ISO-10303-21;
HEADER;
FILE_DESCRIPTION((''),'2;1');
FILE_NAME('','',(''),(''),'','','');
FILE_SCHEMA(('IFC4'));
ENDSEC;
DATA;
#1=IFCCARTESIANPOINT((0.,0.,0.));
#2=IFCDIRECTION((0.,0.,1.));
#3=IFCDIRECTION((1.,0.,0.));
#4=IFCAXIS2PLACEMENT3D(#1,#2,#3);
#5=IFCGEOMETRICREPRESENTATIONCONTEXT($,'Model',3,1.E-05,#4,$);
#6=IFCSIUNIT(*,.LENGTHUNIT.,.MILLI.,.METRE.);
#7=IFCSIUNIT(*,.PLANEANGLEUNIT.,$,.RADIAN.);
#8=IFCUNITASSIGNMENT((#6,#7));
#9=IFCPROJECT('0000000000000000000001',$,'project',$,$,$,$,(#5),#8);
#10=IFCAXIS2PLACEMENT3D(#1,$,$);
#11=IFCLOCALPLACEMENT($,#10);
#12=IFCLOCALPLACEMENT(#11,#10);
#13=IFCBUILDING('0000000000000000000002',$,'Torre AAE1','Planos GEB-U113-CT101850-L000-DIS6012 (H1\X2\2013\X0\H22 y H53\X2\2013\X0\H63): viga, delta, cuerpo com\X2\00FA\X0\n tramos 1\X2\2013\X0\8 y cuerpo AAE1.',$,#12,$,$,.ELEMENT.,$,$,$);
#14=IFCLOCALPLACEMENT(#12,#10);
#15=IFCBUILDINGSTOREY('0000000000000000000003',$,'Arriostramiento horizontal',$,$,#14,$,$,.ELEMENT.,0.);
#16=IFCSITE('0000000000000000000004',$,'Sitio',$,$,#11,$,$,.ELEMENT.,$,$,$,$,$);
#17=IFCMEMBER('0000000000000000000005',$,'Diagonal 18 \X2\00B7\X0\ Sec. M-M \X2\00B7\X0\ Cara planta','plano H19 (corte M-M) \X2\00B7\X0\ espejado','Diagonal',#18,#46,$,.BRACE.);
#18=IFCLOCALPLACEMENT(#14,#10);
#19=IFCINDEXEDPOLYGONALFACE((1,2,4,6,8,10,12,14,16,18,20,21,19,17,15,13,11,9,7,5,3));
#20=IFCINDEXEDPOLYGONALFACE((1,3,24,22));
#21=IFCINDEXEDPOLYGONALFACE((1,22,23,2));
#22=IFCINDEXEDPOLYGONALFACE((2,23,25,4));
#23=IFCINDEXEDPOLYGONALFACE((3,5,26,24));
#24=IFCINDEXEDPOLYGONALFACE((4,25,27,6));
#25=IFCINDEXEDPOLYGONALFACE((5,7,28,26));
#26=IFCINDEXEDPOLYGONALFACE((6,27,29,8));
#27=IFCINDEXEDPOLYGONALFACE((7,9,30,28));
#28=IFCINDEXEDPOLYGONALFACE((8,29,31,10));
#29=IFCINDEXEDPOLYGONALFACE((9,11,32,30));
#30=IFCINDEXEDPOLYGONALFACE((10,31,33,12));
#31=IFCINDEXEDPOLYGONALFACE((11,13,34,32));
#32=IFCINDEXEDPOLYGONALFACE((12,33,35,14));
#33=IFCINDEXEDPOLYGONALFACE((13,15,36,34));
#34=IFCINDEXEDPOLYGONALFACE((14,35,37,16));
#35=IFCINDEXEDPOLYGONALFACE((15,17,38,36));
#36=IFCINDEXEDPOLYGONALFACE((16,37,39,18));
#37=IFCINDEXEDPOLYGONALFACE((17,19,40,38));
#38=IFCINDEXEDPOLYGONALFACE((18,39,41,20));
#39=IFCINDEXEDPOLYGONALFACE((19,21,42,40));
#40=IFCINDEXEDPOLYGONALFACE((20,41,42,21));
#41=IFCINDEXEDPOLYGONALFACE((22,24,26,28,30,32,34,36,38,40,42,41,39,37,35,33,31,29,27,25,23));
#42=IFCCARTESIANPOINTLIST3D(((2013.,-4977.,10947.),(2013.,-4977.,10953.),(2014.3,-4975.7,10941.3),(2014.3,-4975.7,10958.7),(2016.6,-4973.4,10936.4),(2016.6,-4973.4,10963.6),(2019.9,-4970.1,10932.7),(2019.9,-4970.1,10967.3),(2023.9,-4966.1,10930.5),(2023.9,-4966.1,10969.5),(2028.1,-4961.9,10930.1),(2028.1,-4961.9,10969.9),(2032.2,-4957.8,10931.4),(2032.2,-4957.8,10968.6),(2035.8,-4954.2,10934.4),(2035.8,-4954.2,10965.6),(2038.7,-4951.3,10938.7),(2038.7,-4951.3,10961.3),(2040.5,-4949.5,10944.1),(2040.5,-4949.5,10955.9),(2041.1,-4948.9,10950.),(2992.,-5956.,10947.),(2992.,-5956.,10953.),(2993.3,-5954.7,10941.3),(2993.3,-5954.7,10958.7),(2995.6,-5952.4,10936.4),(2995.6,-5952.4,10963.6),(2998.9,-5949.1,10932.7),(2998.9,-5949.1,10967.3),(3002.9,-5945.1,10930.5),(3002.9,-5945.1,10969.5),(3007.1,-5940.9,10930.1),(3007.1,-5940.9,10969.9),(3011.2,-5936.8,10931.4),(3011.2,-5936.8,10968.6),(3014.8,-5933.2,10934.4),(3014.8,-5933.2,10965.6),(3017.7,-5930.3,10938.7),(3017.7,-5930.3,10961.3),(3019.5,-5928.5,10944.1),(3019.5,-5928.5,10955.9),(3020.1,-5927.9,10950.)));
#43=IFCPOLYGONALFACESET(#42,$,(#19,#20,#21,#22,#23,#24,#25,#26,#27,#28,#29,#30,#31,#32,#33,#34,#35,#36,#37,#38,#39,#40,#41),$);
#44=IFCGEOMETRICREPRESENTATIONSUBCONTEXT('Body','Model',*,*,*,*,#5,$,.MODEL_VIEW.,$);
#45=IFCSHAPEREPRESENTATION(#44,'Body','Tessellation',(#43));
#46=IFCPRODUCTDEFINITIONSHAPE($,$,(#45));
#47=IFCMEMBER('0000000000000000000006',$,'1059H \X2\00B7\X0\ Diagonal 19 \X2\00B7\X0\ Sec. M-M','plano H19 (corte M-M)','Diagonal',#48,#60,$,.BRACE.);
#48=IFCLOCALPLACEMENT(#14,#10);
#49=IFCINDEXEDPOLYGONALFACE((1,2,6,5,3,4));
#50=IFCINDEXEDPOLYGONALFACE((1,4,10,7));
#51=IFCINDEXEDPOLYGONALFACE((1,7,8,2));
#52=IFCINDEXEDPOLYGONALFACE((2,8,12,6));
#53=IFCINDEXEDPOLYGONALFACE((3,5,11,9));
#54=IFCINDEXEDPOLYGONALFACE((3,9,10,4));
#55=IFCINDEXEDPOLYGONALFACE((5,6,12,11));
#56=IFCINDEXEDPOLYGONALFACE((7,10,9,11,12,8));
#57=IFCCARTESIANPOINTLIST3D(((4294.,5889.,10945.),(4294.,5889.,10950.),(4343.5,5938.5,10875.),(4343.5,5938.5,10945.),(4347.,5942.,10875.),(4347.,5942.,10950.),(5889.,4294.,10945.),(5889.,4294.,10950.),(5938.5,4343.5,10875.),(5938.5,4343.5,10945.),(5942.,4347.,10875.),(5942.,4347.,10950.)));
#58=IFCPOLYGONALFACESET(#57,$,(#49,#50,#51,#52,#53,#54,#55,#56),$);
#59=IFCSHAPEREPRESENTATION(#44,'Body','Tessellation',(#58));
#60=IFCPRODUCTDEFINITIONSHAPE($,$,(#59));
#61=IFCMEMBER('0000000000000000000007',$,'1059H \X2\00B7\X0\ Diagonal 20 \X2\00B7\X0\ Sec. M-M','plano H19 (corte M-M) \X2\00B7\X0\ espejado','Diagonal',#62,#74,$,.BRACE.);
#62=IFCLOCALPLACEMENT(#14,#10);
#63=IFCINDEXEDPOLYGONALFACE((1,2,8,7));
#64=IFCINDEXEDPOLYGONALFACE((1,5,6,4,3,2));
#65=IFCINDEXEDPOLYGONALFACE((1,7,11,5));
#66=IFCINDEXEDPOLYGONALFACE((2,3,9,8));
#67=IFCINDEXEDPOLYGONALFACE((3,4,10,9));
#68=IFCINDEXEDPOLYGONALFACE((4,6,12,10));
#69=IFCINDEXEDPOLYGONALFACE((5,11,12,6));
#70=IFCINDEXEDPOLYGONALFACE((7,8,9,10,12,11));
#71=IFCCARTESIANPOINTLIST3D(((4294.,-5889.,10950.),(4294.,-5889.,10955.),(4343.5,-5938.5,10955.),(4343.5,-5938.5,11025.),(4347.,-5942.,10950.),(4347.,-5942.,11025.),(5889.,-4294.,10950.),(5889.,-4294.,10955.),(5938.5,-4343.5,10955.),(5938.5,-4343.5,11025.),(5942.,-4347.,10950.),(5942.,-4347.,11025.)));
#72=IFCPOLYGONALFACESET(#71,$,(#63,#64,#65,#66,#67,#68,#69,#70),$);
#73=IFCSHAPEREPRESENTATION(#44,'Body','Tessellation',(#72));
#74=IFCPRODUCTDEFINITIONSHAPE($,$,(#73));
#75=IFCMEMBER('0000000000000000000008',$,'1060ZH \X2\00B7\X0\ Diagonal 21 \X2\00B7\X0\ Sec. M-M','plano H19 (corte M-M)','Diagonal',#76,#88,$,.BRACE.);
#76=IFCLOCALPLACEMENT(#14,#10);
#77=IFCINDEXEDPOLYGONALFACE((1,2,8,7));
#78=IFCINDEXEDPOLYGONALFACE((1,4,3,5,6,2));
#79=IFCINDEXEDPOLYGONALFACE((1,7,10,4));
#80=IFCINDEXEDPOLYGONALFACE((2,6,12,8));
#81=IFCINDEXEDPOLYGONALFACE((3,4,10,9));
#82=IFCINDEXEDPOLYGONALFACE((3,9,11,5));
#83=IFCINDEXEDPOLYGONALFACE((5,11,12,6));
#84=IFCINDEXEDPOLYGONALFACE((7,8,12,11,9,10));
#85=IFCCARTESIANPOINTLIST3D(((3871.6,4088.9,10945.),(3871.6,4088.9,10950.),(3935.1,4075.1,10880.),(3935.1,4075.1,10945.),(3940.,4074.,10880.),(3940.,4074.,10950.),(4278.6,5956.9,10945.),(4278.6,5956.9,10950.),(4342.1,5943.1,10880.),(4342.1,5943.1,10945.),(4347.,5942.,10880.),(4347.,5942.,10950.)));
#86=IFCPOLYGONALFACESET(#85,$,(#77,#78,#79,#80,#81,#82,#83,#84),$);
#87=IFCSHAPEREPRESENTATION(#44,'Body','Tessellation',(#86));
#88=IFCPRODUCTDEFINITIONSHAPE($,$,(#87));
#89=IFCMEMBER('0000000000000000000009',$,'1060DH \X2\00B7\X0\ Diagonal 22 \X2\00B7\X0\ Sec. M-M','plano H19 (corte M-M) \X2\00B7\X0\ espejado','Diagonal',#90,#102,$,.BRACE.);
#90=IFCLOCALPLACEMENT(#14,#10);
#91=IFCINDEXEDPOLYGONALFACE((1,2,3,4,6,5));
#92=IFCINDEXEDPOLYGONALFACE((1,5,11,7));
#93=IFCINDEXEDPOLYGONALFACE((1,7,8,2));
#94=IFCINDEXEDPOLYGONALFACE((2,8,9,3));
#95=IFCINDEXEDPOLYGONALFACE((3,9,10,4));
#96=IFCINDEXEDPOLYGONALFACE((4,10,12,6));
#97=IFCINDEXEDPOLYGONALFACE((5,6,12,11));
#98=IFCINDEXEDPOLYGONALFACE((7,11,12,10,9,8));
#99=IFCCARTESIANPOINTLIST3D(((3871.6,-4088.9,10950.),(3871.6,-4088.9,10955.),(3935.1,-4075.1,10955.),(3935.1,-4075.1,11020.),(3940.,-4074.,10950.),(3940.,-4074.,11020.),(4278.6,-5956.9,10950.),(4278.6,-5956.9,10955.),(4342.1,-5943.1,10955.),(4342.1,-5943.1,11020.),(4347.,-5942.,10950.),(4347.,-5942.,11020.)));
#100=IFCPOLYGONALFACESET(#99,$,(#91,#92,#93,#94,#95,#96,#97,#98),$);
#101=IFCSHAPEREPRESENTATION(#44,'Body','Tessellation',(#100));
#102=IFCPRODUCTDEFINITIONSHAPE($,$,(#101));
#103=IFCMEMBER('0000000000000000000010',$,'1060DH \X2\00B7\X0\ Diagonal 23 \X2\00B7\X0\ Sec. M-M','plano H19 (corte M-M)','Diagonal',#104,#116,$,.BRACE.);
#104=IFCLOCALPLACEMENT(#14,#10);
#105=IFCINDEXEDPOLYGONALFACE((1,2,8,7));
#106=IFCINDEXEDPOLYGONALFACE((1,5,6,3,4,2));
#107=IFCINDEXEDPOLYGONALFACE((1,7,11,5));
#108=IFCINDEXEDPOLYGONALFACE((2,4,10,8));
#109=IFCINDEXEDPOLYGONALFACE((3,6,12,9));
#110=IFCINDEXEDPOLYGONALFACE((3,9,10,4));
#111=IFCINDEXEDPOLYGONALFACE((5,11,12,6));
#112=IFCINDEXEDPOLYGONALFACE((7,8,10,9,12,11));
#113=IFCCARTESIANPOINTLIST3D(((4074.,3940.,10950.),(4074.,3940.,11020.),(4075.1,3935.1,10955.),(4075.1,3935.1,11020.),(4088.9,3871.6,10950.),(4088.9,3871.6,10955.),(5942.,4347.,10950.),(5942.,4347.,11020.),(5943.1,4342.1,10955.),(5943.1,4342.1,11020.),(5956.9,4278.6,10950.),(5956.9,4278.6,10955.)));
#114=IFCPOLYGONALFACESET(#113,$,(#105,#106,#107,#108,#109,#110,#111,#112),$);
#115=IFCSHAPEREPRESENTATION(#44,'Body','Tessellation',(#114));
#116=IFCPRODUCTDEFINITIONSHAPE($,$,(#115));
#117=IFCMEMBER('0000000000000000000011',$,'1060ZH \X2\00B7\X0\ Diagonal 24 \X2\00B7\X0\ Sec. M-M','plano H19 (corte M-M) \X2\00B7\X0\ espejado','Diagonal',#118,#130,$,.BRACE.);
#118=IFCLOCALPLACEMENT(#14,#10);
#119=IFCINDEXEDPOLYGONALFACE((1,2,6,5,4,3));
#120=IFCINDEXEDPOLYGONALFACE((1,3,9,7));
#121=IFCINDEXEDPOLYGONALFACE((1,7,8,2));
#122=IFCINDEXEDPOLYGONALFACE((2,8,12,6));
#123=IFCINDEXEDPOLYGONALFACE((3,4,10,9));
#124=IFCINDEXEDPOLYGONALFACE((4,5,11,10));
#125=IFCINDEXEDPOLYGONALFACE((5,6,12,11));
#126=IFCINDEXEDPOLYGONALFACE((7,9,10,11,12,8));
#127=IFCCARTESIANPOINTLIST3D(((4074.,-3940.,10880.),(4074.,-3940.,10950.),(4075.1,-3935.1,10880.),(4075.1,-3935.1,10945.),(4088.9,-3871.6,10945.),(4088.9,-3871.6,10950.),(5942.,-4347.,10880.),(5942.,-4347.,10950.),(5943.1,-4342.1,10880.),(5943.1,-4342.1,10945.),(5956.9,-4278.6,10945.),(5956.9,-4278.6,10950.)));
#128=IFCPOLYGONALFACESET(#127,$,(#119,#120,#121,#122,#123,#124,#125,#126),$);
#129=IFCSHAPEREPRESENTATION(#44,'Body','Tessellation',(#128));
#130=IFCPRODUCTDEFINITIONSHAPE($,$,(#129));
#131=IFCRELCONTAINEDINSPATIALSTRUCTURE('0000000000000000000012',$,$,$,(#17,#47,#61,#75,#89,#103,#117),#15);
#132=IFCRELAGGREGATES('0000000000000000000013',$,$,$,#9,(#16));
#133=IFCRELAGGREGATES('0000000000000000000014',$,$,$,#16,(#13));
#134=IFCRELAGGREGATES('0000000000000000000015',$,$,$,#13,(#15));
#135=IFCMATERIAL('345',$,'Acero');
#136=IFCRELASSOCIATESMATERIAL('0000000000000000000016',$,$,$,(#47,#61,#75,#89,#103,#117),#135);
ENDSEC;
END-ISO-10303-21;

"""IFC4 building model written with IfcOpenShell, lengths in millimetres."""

from ifc_helpers import new_model, si_unit, frame, frame_2d, origin, origin_with_axes, place, context, subcontext, project, spatial, circle, l_section, extrude, material, element, save


model = new_model("IFC4")

# Units and contexts
model_context = context("Model", 3, precision=1e-05, world=origin_with_axes())
body_context = subcontext(model_context, "Body", "Model", "MODEL_VIEW")
ifc_project = project(units=[si_unit("LENGTHUNIT", "METRE", prefix="MILLI"), si_unit("PLANEANGLEUNIT", "RADIAN")], contexts=[model_context])

# Site, building, storey
site_placement = place(None, origin())
site = spatial("IfcSite", under=ifc_project, at=site_placement, Name="Sitio", CompositionType="ELEMENT")
building_placement = place(site_placement, origin())
building = spatial("IfcBuilding", under=site, at=building_placement, Name="Torre AAE1", Description="Planos GEB-U113-CT101850-L000-DIS6012 (H1–H22 y H53–H63): viga, delta, cuerpo común tramos 1–8 y cuerpo AAE1.", CompositionType="ELEMENT")
storey_placement = place(building_placement, origin())
storey = spatial("IfcBuildingStorey", under=building, at=storey_placement, Name="Arriostramiento horizontal", CompositionType="ELEMENT", Elevation=0.0)

# Members
ifc_material_1 = material(Name="345", Category="Acero")
for number, where, z_axis, x_axis, name in (
    (1, (3006.0, -5942.0, 10950.0), (-0.707107, 0.707107, 0.0), (0.707107, 0.707107, 0.0), "Diagonal 18 · Sec. M-M · Cara planta"),
):
    element("IfcMember", number, at=place(storey_placement, frame(where, z_axis=z_axis, x_axis=x_axis)), inside=storey, Name=name, Description="plano H19 (corte M-M) · espejado", ObjectType="Diagonal", PredefinedType="BRACE", context=body_context, shape_type="SweptSolid", body=[
        extrude(circle(Radius=20.0), None, (0.0, 0.0, 1.0), 1384.5),
    ])
for number, where, z_axis, x_axis, name, description in (
    (2, (4347.0, 5942.0, 10950.0), (0.707107, -0.707107, 0.0), (-0.707107, -0.707107, 0.0), "1059H · Diagonal 19 · Sec. M-M", "plano H19 (corte M-M)"),
    (3, (4347.0, -5942.0, 10950.0), (0.707107, 0.707107, 0.0), (-0.707107, 0.707107, 0.0), "1059H · Diagonal 20 · Sec. M-M", "plano H19 (corte M-M) · espejado"),
):
    element("IfcMember", number, at=place(storey_placement, frame(where, z_axis=z_axis, x_axis=x_axis)), inside=storey, material=ifc_material_1, Name=name, Description=description, ObjectType="Diagonal", PredefinedType="BRACE", context=body_context, shape_type="SweptSolid", body=[
        extrude(l_section(Depth=75.0, Width=75.0, Thickness=5.0, at=frame_2d((37.5, 37.5))), None, (0.0, 0.0, 1.0), 2255.7),
    ])
for number, where, z_axis, x_axis, name, description in (
    (4, (4347.0, 5942.0, 10950.0), (-0.212886, -0.977077, 0.0), (-0.977077, 0.212886, 0.0), "1060ZH · Diagonal 21 · Sec. M-M", "plano H19 (corte M-M)"),
    (5, (4347.0, -5942.0, 10950.0), (-0.212886, 0.977077, 0.0), (-0.977077, -0.212886, 0.0), "1060DH · Diagonal 22 · Sec. M-M", "plano H19 (corte M-M) · espejado"),
    (6, (5942.0, 4347.0, 10950.0), (-0.977077, -0.212886, 0.0), (0.212886, -0.977077, 0.0), "1060DH · Diagonal 23 · Sec. M-M", "plano H19 (corte M-M)"),
    (7, (5942.0, -4347.0, 10950.0), (-0.977077, 0.212886, 0.0), (0.212886, 0.977077, 0.0), "1060ZH · Diagonal 24 · Sec. M-M", "plano H19 (corte M-M) · espejado"),
):
    element("IfcMember", number, at=place(storey_placement, frame(where, z_axis=z_axis, x_axis=x_axis)), inside=storey, material=ifc_material_1, Name=name, Description=description, ObjectType="Diagonal", PredefinedType="BRACE", context=body_context, shape_type="SweptSolid", body=[
        extrude(l_section(Depth=70.0, Width=70.0, Thickness=5.0, at=frame_2d((35.0, 35.0))), None, (0.0, 0.0, 1.0), 1911.8),
    ])

save(model, "model.ifc")
